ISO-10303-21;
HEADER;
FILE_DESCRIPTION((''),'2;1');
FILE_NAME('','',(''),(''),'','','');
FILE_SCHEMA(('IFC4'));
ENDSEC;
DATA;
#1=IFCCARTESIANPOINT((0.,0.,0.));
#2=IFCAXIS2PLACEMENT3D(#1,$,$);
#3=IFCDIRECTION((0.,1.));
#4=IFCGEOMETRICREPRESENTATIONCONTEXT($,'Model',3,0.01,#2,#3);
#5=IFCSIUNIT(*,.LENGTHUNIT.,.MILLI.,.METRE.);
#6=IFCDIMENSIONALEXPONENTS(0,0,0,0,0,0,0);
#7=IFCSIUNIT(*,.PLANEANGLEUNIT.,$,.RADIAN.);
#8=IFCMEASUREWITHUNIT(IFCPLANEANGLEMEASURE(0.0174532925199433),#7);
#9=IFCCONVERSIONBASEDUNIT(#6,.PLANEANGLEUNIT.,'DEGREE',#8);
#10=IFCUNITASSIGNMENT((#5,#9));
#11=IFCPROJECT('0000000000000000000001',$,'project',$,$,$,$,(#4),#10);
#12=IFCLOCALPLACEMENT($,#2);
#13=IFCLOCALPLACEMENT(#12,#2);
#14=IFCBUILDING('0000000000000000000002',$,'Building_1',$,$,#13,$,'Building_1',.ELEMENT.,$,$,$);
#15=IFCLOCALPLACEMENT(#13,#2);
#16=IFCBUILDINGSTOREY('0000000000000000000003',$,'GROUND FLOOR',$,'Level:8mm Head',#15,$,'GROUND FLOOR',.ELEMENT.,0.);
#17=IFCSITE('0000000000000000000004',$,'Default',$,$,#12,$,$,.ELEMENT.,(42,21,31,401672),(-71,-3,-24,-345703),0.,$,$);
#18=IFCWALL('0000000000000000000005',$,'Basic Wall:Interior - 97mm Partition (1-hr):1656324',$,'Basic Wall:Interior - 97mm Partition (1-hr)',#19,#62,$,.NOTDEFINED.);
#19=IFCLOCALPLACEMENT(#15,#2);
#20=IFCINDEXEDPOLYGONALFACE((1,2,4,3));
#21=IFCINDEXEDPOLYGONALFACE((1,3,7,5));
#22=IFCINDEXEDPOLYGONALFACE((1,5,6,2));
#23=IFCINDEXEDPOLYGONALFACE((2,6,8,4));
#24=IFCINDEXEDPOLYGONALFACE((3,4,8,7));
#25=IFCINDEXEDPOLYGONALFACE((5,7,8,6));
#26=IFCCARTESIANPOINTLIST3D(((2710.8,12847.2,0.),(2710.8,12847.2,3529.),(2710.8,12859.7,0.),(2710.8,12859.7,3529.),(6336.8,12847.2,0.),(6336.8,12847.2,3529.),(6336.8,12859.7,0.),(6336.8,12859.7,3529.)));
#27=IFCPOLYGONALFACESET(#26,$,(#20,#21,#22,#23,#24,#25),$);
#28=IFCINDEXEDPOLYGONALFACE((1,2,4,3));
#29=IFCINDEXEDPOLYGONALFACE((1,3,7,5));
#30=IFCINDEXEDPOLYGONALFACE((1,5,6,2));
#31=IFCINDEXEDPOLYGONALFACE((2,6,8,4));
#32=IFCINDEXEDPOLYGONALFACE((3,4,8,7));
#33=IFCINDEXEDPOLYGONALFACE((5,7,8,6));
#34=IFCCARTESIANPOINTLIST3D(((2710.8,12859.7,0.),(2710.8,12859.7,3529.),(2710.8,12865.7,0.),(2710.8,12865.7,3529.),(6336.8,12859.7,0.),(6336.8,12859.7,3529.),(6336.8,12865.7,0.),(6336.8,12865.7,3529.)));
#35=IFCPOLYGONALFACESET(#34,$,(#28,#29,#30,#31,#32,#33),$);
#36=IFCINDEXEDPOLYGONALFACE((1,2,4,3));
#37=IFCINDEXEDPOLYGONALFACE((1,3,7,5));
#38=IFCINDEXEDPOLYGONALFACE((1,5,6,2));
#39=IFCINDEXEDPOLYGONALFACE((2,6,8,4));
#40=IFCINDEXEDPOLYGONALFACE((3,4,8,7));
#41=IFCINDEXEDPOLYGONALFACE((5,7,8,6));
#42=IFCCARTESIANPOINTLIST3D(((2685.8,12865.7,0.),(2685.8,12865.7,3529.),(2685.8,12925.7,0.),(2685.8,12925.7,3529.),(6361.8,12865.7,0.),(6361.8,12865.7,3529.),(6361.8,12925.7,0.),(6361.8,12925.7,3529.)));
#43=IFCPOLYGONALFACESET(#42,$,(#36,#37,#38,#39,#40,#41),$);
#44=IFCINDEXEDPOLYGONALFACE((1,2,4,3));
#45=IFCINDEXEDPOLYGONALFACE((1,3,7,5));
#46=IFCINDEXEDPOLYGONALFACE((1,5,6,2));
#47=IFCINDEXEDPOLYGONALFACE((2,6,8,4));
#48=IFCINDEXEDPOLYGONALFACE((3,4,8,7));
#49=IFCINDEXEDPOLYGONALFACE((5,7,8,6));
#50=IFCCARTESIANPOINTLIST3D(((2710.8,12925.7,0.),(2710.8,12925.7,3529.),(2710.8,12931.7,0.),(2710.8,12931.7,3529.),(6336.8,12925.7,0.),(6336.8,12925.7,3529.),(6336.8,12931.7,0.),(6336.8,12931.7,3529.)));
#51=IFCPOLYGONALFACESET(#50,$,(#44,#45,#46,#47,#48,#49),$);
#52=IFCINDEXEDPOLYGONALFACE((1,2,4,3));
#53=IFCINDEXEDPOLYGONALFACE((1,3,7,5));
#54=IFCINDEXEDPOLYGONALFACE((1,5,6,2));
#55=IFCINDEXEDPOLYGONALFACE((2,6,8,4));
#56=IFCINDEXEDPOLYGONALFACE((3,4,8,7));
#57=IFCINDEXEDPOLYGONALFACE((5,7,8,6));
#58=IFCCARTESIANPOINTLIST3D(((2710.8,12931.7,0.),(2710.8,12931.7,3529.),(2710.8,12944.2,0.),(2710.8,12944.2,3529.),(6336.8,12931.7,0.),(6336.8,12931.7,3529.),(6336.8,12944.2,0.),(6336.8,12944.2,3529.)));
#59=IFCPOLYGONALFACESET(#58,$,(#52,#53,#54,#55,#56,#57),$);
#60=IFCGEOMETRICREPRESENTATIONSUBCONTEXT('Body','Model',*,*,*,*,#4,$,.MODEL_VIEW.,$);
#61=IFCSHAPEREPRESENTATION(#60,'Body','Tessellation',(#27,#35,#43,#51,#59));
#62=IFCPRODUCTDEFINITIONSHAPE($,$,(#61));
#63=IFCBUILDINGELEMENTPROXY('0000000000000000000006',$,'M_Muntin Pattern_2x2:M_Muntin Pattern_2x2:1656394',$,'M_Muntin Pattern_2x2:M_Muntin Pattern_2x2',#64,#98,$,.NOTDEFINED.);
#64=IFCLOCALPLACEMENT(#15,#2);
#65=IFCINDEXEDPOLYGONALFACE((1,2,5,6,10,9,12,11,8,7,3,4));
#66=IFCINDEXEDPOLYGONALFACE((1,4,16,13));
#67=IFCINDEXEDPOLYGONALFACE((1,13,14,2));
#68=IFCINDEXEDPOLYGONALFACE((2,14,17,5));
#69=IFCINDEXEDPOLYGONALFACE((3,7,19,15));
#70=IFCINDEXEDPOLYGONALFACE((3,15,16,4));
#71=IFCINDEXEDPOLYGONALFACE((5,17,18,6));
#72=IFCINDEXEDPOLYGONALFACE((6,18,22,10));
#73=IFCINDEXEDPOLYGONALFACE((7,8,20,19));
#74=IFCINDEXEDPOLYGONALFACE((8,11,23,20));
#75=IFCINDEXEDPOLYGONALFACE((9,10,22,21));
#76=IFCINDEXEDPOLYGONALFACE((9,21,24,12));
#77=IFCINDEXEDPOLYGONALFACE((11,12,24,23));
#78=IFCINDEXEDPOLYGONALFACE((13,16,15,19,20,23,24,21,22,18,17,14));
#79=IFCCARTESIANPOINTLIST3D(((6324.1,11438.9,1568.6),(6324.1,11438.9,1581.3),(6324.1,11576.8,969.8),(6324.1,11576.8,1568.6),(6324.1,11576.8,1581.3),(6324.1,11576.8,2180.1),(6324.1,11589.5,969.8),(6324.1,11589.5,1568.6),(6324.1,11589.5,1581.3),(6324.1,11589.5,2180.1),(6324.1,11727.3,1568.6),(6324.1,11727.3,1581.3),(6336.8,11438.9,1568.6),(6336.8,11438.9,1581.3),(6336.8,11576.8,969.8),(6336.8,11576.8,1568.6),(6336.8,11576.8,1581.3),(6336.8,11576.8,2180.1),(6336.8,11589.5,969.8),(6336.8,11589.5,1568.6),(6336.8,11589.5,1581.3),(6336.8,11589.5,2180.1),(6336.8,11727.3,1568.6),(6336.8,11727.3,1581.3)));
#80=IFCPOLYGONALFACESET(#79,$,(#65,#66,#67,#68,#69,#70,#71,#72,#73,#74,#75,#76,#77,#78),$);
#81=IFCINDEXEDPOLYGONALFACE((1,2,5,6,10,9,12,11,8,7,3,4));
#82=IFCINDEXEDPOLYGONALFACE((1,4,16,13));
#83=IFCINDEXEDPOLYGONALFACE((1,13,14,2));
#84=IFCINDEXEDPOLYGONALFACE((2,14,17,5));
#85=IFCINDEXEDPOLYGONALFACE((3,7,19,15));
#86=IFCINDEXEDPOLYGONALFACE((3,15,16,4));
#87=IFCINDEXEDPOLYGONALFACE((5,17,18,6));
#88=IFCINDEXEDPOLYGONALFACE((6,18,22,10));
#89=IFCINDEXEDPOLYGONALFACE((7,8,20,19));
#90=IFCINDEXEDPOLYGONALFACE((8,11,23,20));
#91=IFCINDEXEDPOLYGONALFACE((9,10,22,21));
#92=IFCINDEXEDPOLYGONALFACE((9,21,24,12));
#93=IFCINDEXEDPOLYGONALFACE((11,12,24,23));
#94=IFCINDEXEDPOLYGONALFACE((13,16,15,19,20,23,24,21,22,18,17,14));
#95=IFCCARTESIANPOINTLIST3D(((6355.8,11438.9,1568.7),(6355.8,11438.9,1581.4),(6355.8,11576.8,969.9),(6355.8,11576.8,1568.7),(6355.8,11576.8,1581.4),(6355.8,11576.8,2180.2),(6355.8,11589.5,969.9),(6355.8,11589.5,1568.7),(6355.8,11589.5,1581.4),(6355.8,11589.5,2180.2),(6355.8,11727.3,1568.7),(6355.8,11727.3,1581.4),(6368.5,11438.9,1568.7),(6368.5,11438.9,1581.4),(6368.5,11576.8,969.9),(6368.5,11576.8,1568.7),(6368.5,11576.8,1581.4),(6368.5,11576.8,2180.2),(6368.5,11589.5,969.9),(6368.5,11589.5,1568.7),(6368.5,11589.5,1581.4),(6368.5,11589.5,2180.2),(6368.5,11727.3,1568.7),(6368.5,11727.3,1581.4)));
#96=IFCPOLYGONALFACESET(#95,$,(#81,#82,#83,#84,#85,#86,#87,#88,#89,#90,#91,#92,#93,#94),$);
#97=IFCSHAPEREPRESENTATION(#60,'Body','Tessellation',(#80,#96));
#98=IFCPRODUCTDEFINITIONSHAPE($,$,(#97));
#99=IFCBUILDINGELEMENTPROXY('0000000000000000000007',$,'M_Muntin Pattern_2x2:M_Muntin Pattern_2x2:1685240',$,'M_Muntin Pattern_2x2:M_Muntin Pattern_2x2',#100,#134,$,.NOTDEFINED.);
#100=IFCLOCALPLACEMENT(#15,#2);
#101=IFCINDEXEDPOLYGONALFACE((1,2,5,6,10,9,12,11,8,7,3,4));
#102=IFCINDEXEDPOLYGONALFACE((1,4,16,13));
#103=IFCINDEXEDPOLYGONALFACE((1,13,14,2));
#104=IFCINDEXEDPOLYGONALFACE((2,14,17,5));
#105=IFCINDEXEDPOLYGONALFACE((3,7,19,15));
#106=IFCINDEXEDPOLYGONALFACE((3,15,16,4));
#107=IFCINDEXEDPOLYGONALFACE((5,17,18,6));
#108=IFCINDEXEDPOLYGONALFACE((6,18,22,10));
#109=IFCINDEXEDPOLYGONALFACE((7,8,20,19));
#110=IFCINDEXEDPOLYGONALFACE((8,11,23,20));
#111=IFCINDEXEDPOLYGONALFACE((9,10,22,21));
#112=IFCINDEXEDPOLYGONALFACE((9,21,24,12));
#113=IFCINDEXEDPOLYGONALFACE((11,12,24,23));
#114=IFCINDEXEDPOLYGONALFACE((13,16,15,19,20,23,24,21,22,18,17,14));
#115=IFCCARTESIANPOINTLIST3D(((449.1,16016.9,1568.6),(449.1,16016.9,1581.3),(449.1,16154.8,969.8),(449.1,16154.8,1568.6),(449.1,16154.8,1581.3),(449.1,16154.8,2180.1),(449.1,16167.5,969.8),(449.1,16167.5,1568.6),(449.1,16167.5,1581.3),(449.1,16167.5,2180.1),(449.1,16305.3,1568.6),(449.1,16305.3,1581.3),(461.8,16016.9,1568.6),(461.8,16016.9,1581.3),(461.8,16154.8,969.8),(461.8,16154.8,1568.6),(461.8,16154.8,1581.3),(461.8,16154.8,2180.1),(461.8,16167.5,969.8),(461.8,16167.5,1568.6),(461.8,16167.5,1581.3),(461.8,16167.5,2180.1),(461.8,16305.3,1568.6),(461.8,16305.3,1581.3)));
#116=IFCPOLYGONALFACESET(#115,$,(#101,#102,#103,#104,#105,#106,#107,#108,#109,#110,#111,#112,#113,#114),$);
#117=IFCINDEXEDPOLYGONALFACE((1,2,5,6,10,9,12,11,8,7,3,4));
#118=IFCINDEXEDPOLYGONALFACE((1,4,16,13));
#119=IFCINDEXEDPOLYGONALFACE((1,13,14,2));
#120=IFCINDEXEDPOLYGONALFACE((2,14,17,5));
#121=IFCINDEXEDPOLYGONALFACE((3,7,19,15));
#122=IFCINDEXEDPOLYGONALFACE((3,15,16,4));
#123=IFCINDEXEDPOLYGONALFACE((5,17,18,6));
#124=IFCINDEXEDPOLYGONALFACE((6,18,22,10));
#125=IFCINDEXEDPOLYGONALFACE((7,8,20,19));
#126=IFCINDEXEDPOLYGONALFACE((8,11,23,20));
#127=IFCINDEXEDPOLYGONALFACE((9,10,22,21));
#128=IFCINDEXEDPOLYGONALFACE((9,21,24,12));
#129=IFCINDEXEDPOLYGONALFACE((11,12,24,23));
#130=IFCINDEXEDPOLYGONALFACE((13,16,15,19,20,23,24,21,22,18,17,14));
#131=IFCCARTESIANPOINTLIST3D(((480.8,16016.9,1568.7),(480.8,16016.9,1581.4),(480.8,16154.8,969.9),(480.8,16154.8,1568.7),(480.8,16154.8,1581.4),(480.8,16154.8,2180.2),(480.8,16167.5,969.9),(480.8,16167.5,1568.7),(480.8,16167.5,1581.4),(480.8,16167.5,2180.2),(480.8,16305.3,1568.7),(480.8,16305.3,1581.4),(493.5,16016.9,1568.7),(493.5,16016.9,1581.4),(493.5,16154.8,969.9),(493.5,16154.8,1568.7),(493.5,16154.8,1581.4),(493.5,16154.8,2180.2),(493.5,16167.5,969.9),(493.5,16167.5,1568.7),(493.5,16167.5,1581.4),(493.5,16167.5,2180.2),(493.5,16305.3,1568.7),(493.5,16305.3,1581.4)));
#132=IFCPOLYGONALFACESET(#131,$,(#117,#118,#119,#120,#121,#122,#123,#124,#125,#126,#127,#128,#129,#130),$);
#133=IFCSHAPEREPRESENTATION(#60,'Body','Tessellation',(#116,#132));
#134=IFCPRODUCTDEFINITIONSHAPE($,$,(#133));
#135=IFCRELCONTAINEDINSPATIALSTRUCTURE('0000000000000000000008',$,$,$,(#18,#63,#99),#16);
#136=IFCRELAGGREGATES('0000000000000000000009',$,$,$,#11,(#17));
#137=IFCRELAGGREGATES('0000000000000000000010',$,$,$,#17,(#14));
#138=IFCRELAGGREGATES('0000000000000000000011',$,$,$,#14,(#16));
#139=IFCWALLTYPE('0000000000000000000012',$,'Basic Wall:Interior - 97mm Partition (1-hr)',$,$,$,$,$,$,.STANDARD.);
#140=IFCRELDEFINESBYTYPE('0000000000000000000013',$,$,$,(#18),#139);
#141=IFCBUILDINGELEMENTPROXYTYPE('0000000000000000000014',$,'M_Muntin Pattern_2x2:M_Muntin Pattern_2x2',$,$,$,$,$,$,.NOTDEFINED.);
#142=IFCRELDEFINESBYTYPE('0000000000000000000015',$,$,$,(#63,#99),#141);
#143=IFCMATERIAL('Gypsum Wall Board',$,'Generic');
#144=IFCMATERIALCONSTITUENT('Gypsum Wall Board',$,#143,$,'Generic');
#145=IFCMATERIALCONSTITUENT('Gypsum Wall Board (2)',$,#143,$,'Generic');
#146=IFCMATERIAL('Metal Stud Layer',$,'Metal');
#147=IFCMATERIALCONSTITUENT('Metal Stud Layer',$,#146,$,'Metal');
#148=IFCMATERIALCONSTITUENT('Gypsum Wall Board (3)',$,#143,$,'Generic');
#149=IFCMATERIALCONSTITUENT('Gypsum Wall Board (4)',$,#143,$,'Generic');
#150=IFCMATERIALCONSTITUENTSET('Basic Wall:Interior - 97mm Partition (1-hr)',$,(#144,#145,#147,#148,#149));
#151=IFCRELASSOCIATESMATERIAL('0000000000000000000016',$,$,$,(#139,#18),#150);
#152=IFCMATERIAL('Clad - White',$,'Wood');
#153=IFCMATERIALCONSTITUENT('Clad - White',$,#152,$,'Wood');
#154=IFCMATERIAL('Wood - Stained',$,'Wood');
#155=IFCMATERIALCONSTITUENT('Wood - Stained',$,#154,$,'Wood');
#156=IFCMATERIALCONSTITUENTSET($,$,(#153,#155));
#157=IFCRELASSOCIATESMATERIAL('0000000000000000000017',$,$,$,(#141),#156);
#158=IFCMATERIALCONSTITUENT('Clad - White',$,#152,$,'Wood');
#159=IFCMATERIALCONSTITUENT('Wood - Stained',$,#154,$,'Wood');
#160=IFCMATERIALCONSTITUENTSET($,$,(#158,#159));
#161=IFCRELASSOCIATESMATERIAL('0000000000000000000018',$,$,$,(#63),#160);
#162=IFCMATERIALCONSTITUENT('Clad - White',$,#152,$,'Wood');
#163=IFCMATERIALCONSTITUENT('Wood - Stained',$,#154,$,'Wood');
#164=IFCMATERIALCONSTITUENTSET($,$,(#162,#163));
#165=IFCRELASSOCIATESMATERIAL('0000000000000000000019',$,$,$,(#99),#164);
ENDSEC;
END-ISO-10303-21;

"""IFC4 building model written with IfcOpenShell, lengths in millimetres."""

from ifc_helpers import new_model, entity, si_unit, converted_unit, direction, frame, origin, place, context, subcontext, project, spatial, indexed_curve, outline, extrude, source, transform, mapped, material, constituent, constituent_set, type_object, type_shapes, element, save


model = new_model("IFC4")

# Units and contexts
model_context = context("Model", 3, precision=0.01, world=origin(), true_north=direction((0.0, 1.0)))
body_context = subcontext(model_context, "Body", "Model", "MODEL_VIEW")
ifc_project = project(units=[si_unit("LENGTHUNIT", "METRE", prefix="MILLI"), converted_unit("PLANEANGLEUNIT", "DEGREE", entity("IfcPlaneAngleMeasure", 0.0174532925199433), si_unit("PLANEANGLEUNIT", "RADIAN"), dimensions=[0, 0, 0, 0, 0, 0, 0])], contexts=[model_context])

# Site, building, storey
site_placement = place(None, origin())
site = spatial("IfcSite", under=ifc_project, at=site_placement, Name="Default", CompositionType="ELEMENT", RefLatitude=(42, 21, 31, 401672), RefLongitude=(-71, -3, -24, -345703), RefElevation=0.0)
building_placement = place(site_placement, origin())
building = spatial("IfcBuilding", under=site, at=building_placement, Name="Building_1", LongName="Building_1", CompositionType="ELEMENT")
storey_placement = place(building_placement, origin())
storey = spatial("IfcBuildingStorey", under=building, at=storey_placement, Name="GROUND FLOOR", ObjectType="Level:8mm Head", LongName="GROUND FLOOR", CompositionType="ELEMENT", Elevation=0.0)

# Shared definitions
ifc_material_1 = material(Name="Wood - Stained", Category="Wood")

# Wall
ifc_material_2 = material(Name="Gypsum Wall Board", Category="Generic")
ifc_constituent_1 = constituent(ifc_material_2, Name="Gypsum Wall Board", Category="Generic")
ifc_constituent_2 = constituent(ifc_material_2, Name="Gypsum Wall Board (2)", Category="Generic")
ifc_material_3 = material(Name="Metal Stud Layer", Category="Metal")
ifc_constituent_3 = constituent(ifc_material_3, Name="Metal Stud Layer", Category="Metal")
ifc_constituent_4 = constituent(ifc_material_2, Name="Gypsum Wall Board (3)", Category="Generic")
ifc_constituent_5 = constituent(ifc_material_2, Name="Gypsum Wall Board (4)", Category="Generic")
ifc_constituent_set_1 = constituent_set(constituents=[ifc_constituent_1, ifc_constituent_2, ifc_constituent_3, ifc_constituent_4, ifc_constituent_5], Name="Basic Wall:Interior - 97mm Partition (1-hr)")
wall_type_1 = type_object("IfcWallType", Name="Basic Wall:Interior - 97mm Partition (1-hr)", PredefinedType="STANDARD", material=ifc_constituent_set_1)
wall_1_placement = place(storey_placement, frame((6336.8, 12895.7, 0.0), z_axis=(0.0, 0.0, 1.0), x_axis=(-1.0, 0.0, 0.0)))
element("IfcWall", 1, at=wall_1_placement, inside=storey, type_object=wall_type_1, material=ifc_constituent_set_1, Name="Basic Wall:Interior - 97mm Partition (1-hr):1656324", ObjectType="Basic Wall:Interior - 97mm Partition (1-hr)", PredefinedType="NOTDEFINED", context=body_context, shape_type="SweptSolid", body=[
    extrude(outline(indexed_curve([(-6.2, -1764.5), (6.3, -1764.5), (6.3, 1764.5), (-6.2, 1764.5), (-6.2, -1764.5)], self_intersect=False)), frame((3626.0, 42.2, 1764.5), z_axis=(-1.0, 0.0, 0.0), x_axis=(0.0, -1.0, 0.0)), (0.0, 0.0, 1.0), 3626.0),
    extrude(outline(indexed_curve([(-1764.5, -3.0), (1764.5, -3.0), (1764.5, 3.0), (-1764.5, 3.0), (-1764.5, -3.0)], self_intersect=False)), frame((3626.0, 33.0, 1764.5), z_axis=(-1.0, 0.0, 0.0), x_axis=(0.0, 0.0, 1.0)), (0.0, 0.0, 1.0), 3626.0),
    extrude(outline(indexed_curve([(-1764.5, -30.0), (1764.5, -30.0), (1764.5, 30.0), (-1764.5, 30.0), (-1764.5, -30.0)], self_intersect=False)), frame((3651.0, 0.0, 1764.5), z_axis=(-1.0, 0.0, 0.0), x_axis=(0.0, 0.0, 1.0)), (0.0, 0.0, 1.0), 3676.0),
    extrude(outline(indexed_curve([(-1764.5, -3.0), (1764.5, -3.0), (1764.5, 3.0), (-1764.5, 3.0), (-1764.5, -3.0)], self_intersect=False)), frame((3626.0, -33.0, 1764.5), z_axis=(-1.0, 0.0, 0.0), x_axis=(0.0, 0.0, 1.0)), (0.0, 0.0, 1.0), 3626.0),
    extrude(outline(indexed_curve([(-6.2, -1764.5), (6.3, -1764.5), (6.3, 1764.5), (-6.2, 1764.5), (-6.2, -1764.5)], self_intersect=False)), frame((3626.0, -42.3, 1764.5), z_axis=(-1.0, 0.0, 0.0), x_axis=(0.0, 1.0, 0.0)), (0.0, 0.0, 1.0), 3626.0),
])

# Building element proxies
ifc_material_4 = material(Name="Clad - White", Category="Wood")
ifc_constituent_6 = constituent(ifc_material_4, Name="Clad - White", Category="Wood")
ifc_constituent_7 = constituent(ifc_material_1, Name="Wood - Stained", Category="Wood")
ifc_constituent_set_2 = constituent_set(constituents=[ifc_constituent_6, ifc_constituent_7])
ifc_constituent_8 = constituent(ifc_material_4, Name="Clad - White", Category="Wood")
ifc_constituent_9 = constituent(ifc_material_1, Name="Wood - Stained", Category="Wood")
ifc_constituent_set_3 = constituent_set(constituents=[ifc_constituent_8, ifc_constituent_9])
building_element_proxy_type_1 = type_object("IfcBuildingElementProxyType", Name="M_Muntin Pattern_2x2:M_Muntin Pattern_2x2", PredefinedType="NOTDEFINED", material=ifc_constituent_set_3)
shared_shape_1 = source(origin(), body_context, "Body", "SweptSolid", [
    extrude(outline(indexed_curve([(6.4, -6.4), (605.1, -6.4), (605.1, 6.3), (6.4, 6.3), (6.4, 144.2), (-6.3, 144.2), (-6.3, 6.3), (-605.2, 6.3), (-605.2, -6.4), (-6.3, -6.4), (-6.3, -144.2), (6.4, -144.2), (6.4, -6.4)], self_intersect=False)), frame((0.0, -22.2, 605.1), z_axis=(0.0, 1.0, 0.0), x_axis=(0.0, 0.0, 1.0)), (0.0, 0.0, 1.0), 12.7),
    extrude(outline(indexed_curve([(6.4, -6.4), (605.2, -6.4), (605.2, 6.3), (6.4, 6.3), (6.4, 144.2), (-6.3, 144.2), (-6.3, 6.3), (-605.2, 6.3), (-605.2, -6.4), (-6.3, -6.4), (-6.3, -144.2), (6.4, -144.2), (6.4, -6.4)], self_intersect=False)), frame((0.0, 9.5, 605.2), z_axis=(0.0, 1.0, 0.0), x_axis=(0.0, 0.0, 1.0)), (0.0, 0.0, 1.0), 12.7),
])
type_shapes(building_element_proxy_type_1, [shared_shape_1])
proxy_1_placement = place(storey_placement, frame((6346.3, 11583.1, 969.9), z_axis=(0.0, 0.0, 1.0), x_axis=(0.0, -1.0, 0.0)))
element("IfcBuildingElementProxy", 2, at=proxy_1_placement, inside=storey, type_object=building_element_proxy_type_1, material=ifc_constituent_set_2, Name="M_Muntin Pattern_2x2:M_Muntin Pattern_2x2:1656394", ObjectType="M_Muntin Pattern_2x2:M_Muntin Pattern_2x2", PredefinedType="NOTDEFINED", context=body_context, shape_type="MappedRepresentation", body=[
    mapped(shared_shape_1, transform((0.0, 0.0, 0.0), scale=1.0)),
])
ifc_constituent_10 = constituent(ifc_material_4, Name="Clad - White", Category="Wood")
ifc_constituent_11 = constituent(ifc_material_1, Name="Wood - Stained", Category="Wood")
ifc_constituent_set_4 = constituent_set(constituents=[ifc_constituent_10, ifc_constituent_11])
proxy_2_placement = place(storey_placement, frame((471.3, 16161.1, 969.9), z_axis=(0.0, 0.0, 1.0), x_axis=(0.0, -1.0, 0.0)))
element("IfcBuildingElementProxy", 3, at=proxy_2_placement, inside=storey, type_object=building_element_proxy_type_1, material=ifc_constituent_set_4, Name="M_Muntin Pattern_2x2:M_Muntin Pattern_2x2:1685240", ObjectType="M_Muntin Pattern_2x2:M_Muntin Pattern_2x2", PredefinedType="NOTDEFINED", context=body_context, shape_type="MappedRepresentation", body=[
    mapped(shared_shape_1, transform((0.0, 0.0, 0.0), scale=1.0)),
])

save(model, "model.ifc")
